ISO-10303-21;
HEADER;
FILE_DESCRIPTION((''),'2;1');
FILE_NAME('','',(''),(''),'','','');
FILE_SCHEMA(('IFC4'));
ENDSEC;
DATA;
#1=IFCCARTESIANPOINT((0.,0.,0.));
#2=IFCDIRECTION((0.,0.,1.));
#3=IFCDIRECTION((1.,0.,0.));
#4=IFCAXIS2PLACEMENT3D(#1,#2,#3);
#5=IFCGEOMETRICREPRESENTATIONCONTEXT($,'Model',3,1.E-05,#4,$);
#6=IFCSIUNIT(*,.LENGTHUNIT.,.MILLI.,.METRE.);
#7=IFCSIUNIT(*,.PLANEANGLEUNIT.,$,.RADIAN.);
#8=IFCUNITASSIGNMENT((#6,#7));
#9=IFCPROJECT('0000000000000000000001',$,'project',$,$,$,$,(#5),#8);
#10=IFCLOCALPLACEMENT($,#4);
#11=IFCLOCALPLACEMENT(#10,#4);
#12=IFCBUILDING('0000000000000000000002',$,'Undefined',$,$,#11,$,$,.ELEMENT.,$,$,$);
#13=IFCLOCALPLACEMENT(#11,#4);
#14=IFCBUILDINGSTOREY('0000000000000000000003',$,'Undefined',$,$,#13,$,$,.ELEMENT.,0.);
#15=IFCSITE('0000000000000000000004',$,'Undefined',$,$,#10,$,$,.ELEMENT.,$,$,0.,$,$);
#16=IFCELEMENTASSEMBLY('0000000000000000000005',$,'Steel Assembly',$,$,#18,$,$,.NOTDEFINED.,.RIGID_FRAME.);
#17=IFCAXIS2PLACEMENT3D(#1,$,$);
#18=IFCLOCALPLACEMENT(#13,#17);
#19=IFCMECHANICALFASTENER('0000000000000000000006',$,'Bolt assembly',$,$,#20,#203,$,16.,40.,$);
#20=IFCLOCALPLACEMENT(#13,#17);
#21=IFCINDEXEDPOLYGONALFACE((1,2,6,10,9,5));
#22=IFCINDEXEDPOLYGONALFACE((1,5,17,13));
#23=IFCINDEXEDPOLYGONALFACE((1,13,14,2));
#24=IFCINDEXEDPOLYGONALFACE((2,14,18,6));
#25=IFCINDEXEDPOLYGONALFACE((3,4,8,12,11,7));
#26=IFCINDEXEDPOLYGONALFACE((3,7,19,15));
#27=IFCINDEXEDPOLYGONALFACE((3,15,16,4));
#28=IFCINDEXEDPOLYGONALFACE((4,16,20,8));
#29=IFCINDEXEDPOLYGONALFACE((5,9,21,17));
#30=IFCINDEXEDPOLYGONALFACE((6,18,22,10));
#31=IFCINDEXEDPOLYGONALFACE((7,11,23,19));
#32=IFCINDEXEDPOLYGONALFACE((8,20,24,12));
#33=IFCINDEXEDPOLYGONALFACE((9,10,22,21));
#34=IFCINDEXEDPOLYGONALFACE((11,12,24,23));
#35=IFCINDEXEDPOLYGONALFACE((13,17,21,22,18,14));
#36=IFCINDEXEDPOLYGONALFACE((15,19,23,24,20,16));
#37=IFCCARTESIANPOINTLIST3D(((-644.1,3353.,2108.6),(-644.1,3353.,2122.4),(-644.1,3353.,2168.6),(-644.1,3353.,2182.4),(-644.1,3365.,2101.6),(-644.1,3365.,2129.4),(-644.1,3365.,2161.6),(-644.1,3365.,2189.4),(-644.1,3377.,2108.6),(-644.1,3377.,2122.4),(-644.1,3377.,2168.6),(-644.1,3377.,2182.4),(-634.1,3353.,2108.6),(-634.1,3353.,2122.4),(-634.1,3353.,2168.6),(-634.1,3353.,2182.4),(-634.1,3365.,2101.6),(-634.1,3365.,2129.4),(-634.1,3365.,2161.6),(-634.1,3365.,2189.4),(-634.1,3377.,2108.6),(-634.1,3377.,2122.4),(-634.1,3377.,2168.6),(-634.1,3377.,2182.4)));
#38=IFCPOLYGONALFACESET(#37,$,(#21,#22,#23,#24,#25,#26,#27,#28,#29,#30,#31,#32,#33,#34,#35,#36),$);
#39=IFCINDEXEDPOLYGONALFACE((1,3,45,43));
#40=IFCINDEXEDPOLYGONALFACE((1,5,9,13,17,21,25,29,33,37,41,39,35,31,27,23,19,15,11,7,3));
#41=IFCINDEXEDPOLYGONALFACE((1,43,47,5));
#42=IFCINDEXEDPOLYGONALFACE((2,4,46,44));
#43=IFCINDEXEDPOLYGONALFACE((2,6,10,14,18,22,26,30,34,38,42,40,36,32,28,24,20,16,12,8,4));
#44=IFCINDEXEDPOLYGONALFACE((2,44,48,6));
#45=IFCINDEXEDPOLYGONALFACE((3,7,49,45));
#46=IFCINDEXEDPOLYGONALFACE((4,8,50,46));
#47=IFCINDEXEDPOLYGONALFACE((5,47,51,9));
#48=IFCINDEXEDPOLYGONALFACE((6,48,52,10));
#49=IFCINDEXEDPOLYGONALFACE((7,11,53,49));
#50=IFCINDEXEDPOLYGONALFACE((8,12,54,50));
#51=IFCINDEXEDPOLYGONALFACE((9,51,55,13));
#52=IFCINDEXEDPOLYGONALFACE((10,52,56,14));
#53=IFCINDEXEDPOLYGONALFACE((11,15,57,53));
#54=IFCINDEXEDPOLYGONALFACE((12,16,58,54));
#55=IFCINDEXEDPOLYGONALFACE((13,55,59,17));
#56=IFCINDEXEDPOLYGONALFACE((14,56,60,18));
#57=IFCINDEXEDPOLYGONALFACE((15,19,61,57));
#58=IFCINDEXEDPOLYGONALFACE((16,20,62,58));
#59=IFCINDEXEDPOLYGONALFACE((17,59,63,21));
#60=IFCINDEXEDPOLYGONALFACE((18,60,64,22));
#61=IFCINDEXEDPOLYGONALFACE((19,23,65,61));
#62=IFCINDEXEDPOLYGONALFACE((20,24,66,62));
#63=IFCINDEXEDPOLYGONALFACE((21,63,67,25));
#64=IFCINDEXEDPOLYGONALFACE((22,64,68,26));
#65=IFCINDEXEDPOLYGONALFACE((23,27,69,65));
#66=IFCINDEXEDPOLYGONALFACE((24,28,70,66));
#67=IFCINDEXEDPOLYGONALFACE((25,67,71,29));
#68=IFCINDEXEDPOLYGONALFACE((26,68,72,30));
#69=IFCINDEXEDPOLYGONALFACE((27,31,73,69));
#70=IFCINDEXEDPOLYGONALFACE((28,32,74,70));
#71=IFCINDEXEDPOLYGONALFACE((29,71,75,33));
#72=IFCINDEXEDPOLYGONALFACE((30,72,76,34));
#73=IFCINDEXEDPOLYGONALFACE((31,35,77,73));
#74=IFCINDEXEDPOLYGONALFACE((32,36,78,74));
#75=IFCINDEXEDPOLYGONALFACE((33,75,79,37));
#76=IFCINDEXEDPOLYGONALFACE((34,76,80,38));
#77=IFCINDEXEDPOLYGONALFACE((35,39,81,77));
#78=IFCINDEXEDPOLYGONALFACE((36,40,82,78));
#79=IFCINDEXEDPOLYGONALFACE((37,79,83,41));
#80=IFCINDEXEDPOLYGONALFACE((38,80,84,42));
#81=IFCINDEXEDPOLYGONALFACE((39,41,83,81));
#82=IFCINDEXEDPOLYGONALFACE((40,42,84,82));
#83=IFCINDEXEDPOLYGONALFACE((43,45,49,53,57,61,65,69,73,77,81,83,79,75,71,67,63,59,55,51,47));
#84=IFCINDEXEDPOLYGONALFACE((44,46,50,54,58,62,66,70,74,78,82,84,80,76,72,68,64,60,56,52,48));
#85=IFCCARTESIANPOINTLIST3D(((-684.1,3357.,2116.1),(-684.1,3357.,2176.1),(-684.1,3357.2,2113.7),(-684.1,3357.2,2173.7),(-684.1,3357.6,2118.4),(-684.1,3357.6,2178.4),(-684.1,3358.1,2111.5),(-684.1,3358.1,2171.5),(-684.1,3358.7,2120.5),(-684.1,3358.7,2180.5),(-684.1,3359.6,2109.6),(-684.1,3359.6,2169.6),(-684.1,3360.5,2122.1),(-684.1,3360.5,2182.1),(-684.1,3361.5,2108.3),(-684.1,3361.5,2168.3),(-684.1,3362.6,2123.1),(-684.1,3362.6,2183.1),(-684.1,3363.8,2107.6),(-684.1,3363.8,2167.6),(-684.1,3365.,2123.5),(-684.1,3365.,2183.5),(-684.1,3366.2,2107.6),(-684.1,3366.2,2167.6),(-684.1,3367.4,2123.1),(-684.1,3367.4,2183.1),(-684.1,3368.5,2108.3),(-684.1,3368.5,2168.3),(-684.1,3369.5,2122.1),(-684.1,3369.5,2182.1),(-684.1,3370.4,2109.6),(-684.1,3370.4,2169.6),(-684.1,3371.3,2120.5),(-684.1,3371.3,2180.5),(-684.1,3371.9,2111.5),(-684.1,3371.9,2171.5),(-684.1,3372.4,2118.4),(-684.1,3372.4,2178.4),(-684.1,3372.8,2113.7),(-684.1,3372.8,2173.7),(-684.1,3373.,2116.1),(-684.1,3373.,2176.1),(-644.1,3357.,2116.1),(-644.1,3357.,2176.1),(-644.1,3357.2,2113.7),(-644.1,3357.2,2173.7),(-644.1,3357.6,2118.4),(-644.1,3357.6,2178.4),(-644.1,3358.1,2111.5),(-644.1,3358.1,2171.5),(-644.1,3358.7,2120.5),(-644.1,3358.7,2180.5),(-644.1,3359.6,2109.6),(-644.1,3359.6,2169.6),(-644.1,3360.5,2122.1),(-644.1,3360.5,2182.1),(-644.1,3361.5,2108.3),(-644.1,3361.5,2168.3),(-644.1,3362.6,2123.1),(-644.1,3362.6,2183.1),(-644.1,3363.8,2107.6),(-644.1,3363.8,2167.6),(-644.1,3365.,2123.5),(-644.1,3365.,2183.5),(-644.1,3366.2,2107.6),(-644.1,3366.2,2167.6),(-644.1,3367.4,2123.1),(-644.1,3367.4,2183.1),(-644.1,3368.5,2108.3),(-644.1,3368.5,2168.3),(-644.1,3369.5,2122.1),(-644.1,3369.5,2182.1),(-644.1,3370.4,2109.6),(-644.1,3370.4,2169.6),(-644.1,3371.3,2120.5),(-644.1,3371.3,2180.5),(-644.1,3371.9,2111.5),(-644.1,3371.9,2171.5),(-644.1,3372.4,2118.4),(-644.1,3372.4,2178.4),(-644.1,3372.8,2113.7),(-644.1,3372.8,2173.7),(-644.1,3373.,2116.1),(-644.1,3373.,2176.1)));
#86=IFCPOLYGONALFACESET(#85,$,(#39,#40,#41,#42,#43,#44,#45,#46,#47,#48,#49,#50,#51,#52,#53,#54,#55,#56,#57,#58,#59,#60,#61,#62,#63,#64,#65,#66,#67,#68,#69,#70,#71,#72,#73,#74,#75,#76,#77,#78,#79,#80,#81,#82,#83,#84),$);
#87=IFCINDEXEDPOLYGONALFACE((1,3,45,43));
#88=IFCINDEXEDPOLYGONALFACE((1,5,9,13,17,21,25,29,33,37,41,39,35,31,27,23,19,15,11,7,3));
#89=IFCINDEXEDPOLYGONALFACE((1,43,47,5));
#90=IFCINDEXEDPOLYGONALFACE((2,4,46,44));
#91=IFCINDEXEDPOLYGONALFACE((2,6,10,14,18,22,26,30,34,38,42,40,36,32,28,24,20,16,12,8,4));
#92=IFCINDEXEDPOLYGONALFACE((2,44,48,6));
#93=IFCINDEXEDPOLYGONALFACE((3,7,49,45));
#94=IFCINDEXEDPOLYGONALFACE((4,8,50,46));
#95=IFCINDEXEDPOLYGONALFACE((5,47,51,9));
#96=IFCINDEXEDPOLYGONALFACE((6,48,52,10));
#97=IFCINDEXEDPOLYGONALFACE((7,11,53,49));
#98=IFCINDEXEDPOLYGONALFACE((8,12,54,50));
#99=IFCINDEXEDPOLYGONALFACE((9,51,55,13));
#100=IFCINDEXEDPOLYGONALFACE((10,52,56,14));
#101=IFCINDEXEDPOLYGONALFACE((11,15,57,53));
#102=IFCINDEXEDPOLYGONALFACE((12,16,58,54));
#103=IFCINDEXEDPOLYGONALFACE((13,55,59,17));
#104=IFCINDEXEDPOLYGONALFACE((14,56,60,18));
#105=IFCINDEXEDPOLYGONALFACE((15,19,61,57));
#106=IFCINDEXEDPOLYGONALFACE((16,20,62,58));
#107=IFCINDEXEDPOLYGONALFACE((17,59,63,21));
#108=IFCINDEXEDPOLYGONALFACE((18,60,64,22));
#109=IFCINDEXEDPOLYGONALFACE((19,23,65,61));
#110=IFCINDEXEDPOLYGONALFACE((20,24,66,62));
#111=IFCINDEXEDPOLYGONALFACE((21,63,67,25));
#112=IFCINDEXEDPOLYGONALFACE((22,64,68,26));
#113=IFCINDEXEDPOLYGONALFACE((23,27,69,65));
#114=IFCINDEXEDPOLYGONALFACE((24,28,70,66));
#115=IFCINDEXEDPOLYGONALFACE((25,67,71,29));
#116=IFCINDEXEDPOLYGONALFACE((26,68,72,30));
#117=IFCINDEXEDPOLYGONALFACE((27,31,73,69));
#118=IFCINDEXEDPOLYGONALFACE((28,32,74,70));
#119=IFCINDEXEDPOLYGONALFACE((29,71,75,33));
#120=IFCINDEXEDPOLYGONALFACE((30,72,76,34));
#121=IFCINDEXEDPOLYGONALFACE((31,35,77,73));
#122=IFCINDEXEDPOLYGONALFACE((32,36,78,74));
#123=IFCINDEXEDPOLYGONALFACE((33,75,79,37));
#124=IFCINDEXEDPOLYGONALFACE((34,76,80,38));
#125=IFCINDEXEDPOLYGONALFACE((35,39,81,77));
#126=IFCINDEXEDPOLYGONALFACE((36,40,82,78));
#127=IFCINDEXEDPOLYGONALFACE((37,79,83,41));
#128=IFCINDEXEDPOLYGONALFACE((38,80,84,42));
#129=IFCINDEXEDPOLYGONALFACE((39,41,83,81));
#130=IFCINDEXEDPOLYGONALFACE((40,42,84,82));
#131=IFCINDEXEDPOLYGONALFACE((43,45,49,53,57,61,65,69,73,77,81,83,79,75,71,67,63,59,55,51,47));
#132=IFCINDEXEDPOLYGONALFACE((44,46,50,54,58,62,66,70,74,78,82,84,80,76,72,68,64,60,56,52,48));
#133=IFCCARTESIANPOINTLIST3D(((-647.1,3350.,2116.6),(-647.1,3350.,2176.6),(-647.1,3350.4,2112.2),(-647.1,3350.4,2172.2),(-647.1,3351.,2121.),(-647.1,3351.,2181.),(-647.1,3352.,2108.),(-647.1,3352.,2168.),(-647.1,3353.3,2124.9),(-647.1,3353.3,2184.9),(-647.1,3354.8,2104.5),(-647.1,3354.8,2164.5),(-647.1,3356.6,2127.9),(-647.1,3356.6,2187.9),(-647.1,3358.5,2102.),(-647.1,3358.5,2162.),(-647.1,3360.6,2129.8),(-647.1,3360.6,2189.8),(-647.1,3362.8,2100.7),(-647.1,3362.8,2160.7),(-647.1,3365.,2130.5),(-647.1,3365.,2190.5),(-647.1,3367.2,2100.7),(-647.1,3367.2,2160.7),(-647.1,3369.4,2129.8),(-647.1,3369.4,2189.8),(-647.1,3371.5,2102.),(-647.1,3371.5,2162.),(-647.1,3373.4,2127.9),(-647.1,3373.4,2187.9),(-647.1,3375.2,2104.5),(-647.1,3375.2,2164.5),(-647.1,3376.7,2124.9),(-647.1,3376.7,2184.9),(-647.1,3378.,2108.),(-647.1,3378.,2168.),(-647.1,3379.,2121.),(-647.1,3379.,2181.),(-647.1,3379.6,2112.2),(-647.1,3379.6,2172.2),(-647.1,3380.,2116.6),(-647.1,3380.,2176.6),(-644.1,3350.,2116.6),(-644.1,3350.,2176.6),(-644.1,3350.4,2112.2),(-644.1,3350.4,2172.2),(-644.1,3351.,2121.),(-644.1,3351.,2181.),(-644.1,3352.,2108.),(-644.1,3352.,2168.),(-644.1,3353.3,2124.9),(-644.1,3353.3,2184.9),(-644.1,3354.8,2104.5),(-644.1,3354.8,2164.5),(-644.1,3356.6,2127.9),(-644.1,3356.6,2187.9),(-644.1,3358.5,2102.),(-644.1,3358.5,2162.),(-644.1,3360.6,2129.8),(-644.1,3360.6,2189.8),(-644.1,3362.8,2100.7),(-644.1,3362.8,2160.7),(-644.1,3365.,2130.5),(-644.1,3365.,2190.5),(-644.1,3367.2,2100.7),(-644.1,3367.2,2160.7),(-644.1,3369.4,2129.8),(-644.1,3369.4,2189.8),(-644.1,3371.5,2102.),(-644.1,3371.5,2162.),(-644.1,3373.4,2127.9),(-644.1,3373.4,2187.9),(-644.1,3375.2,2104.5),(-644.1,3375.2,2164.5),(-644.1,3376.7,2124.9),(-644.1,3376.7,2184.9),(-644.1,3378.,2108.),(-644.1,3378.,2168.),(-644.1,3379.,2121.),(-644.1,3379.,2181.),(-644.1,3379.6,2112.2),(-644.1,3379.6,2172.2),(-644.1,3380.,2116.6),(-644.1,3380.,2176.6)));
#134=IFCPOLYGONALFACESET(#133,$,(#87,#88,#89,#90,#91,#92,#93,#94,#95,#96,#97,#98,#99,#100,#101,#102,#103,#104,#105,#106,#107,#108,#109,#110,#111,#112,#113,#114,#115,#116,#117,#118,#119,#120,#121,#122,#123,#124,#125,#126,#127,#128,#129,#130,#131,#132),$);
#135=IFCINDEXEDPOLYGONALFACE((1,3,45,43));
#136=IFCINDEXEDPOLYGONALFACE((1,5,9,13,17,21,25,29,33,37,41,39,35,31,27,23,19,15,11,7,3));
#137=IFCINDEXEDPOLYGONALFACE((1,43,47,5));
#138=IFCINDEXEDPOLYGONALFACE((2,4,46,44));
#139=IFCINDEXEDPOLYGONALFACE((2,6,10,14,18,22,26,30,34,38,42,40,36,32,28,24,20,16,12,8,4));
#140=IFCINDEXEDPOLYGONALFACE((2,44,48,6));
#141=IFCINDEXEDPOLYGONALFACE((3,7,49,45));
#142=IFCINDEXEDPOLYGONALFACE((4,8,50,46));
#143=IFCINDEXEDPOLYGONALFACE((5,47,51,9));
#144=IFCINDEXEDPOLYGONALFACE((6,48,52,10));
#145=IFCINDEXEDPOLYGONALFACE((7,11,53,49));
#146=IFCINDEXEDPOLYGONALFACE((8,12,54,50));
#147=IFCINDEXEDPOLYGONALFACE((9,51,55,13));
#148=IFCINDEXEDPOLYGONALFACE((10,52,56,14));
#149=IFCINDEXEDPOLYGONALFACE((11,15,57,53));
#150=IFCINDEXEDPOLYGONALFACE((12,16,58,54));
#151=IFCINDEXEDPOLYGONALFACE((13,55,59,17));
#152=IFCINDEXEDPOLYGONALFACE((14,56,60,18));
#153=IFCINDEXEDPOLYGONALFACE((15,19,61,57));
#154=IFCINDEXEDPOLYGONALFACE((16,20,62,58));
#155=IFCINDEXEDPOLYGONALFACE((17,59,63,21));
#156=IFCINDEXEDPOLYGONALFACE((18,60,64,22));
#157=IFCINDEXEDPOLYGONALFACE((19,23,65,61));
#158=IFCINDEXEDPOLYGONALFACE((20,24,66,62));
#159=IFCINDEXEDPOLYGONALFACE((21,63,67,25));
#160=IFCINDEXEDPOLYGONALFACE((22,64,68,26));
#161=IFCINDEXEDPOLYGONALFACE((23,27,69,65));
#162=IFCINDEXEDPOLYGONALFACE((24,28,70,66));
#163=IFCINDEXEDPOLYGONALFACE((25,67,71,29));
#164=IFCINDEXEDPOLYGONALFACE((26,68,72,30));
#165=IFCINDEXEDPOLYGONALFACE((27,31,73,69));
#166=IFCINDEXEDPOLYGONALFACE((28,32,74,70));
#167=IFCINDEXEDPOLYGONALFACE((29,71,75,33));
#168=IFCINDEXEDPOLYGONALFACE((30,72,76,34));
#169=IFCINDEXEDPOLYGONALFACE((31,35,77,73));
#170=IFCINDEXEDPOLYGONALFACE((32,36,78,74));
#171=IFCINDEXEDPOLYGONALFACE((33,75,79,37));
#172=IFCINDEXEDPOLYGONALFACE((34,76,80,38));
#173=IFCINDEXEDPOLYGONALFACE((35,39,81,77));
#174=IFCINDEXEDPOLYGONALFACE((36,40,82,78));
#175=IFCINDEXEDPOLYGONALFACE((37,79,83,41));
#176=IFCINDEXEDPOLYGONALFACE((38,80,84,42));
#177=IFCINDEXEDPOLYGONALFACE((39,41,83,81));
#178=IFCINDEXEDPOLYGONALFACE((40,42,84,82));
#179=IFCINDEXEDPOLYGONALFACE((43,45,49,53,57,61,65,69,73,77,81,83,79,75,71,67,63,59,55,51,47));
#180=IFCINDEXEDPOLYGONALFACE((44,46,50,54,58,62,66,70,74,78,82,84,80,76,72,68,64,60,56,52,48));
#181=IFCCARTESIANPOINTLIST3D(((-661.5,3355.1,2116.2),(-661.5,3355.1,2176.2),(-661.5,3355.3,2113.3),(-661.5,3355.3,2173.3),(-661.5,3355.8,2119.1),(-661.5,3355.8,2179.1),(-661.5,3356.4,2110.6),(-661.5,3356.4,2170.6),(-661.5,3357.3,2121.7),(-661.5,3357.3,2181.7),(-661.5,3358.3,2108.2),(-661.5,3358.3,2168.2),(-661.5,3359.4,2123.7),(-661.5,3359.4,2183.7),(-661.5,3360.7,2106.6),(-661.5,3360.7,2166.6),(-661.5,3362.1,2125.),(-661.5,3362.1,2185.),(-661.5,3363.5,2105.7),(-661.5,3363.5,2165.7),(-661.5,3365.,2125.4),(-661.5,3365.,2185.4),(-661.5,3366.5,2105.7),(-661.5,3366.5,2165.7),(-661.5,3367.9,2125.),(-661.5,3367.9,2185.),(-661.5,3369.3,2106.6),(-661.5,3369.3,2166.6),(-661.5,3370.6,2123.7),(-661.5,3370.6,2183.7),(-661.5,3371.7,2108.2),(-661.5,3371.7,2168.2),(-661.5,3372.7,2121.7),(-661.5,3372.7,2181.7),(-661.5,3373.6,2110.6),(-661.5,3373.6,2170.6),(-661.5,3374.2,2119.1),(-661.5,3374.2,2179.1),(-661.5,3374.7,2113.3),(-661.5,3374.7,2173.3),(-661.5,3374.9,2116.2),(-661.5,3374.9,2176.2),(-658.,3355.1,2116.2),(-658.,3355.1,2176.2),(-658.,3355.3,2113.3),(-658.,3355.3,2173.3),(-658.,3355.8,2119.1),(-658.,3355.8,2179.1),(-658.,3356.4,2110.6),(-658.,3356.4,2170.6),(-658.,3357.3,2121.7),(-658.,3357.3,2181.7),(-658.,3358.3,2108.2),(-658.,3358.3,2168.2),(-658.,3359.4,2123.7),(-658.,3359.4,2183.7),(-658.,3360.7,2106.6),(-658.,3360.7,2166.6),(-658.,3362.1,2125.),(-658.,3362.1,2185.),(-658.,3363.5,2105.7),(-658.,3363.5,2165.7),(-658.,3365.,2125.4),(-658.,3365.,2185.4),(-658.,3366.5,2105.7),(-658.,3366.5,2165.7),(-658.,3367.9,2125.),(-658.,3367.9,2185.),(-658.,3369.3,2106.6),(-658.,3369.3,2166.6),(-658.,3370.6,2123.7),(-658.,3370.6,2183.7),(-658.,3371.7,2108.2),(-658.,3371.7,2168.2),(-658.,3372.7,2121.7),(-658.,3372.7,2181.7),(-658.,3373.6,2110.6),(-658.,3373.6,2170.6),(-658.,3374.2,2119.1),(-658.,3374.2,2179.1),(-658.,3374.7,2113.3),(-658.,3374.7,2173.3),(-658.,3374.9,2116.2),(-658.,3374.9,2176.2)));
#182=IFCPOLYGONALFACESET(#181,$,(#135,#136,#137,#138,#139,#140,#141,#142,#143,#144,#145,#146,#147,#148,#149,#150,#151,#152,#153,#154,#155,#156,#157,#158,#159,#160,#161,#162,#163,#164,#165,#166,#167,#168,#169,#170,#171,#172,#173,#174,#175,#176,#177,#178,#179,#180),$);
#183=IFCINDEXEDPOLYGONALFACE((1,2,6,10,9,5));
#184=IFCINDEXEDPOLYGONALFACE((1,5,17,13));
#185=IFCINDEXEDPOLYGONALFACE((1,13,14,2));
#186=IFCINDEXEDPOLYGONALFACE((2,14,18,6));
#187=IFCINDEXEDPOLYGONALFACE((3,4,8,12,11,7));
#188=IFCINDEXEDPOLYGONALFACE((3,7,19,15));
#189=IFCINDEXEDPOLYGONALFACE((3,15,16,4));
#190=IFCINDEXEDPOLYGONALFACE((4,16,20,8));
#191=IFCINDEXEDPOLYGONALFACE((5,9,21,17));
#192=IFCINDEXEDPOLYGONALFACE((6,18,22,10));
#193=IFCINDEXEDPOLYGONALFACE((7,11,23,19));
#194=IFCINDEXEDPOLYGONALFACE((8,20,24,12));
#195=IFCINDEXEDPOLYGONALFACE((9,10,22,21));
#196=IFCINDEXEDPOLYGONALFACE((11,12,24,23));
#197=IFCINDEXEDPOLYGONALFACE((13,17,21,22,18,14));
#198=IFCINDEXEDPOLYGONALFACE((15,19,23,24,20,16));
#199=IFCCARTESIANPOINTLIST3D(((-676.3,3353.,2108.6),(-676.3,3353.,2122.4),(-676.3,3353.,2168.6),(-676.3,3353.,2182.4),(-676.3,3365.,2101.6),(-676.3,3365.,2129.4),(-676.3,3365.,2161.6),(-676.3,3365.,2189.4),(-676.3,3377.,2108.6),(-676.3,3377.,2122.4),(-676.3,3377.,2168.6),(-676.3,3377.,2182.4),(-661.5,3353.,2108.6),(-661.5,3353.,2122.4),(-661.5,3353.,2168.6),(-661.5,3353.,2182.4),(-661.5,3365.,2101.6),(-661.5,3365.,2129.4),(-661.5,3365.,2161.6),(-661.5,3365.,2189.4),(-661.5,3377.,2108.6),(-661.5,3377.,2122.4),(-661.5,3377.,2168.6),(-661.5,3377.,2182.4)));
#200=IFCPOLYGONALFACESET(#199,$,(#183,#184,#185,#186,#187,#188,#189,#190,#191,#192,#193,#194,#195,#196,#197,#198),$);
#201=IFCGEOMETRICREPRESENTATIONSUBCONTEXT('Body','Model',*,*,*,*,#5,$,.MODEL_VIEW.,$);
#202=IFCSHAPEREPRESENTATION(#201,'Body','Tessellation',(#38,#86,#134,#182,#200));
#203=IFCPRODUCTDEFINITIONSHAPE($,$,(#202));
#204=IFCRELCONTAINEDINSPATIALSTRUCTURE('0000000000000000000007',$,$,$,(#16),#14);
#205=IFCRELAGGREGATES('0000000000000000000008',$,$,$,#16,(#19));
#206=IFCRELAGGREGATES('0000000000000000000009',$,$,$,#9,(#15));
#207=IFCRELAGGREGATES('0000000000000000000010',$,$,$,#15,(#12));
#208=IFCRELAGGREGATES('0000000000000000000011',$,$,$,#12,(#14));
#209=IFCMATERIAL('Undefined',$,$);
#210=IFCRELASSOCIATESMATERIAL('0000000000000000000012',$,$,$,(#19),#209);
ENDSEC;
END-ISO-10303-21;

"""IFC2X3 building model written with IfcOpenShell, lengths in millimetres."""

from ifc_helpers import new_model, si_unit, frame, origin_with_axes, origin_2d_with_axis, place, context, subcontext, project, spatial, polyline, circle, outline, extrude, source, transform, mapped, material, element, aggregate, save


model = new_model("IFC2X3")

# Units and contexts
model_context = context("Model", 3, precision=1e-05, world=origin_with_axes())
body_context = subcontext(model_context, "Body", "Model", "MODEL_VIEW")
ifc_project = project(units=[si_unit("LENGTHUNIT", "METRE", prefix="MILLI"), si_unit("PLANEANGLEUNIT", "RADIAN")], contexts=[model_context])

# Site, building, storey
site_placement = place(None, origin_with_axes())
site = spatial("IfcSite", under=ifc_project, at=site_placement, Name="Undefined", CompositionType="ELEMENT", RefElevation=0.0)
building_placement = place(site_placement, origin_with_axes())
building = spatial("IfcBuilding", under=site, at=building_placement, Name="Undefined", CompositionType="ELEMENT")
storey_placement = place(building_placement, origin_with_axes())
storey = spatial("IfcBuildingStorey", under=building, at=storey_placement, Name="Undefined", CompositionType="ELEMENT", Elevation=0.0)

# Element assembly, mechanical fastener
ifc_material_1 = material(Name="Undefined")
shared_shape_1 = source(origin_with_axes(), body_context, "Body", "SweptSolid", [
    extrude(outline(polyline([(13.9, 0.0), (6.9, 12.0), (-6.9, 12.0), (-13.9, 0.0), (-6.9, -12.0), (6.9, -12.0), (13.9, 0.0)])), frame((0.0, -17.9, 0.0), z_axis=(0.0, 1.0, 0.0), x_axis=(1.0, 0.0, 0.0)), (0.0, 0.0, 1.0), 10.0),
    extrude(circle(Radius=8.0, at=origin_2d_with_axis()), frame((0.0, -7.9, 0.0), z_axis=(0.0, 1.0, 0.0), x_axis=(1.0, 0.0, 0.0)), (0.0, 0.0, 1.0), 40.0),
    extrude(circle(Radius=15.0, at=origin_2d_with_axis()), frame((0.0, -7.9, 0.0), z_axis=(0.0, 1.0, 0.0), x_axis=(1.0, 0.0, 0.0)), (0.0, 0.0, 1.0), 3.0),
    extrude(circle(Radius=9.9, at=origin_2d_with_axis()), frame((0.0, 6.0, 0.0), z_axis=(0.0, 1.0, 0.0), x_axis=(1.0, 0.0, 0.0)), (0.0, 0.0, 1.0), 3.5),
    extrude(outline(polyline([(13.9, 0.0), (6.9, 12.0), (-6.9, 12.0), (-13.9, 0.0), (-6.9, -12.0), (6.9, -12.0), (13.9, 0.0)])), frame((0.0, 9.5, 0.0), z_axis=(0.0, 1.0, 0.0), x_axis=(1.0, 0.0, 0.0)), (0.0, 0.0, 1.0), 14.8),
])
assembly_1_placement = place(storey_placement, origin_with_axes())
assembly_1 = element("IfcElementAssembly", 1, at=assembly_1_placement, inside=storey, Name="Steel Assembly", AssemblyPlace="NOTDEFINED", PredefinedType="RIGID_FRAME")
mechanical_fastener_1_placement = place(assembly_1_placement, frame((-652.0, 3365.0, 2115.5), z_axis=(0.0, -1.0, 0.0), x_axis=(0.0, 0.0, 1.0)))
mechanical_fastener_1 = element("IfcMechanicalFastener", 2, at=mechanical_fastener_1_placement, material=ifc_material_1, Name="Bolt assembly", NominalDiameter=16.0, NominalLength=40.0, context=body_context, shape_type="MappedRepresentation", body=[
    mapped(shared_shape_1, transform((0.0, 0.0, 0.0))),
    mapped(shared_shape_1, transform((60.0, 0.0, 0.0))),
])
aggregate(assembly_1, [mechanical_fastener_1])

save(model, "model.ifc")
